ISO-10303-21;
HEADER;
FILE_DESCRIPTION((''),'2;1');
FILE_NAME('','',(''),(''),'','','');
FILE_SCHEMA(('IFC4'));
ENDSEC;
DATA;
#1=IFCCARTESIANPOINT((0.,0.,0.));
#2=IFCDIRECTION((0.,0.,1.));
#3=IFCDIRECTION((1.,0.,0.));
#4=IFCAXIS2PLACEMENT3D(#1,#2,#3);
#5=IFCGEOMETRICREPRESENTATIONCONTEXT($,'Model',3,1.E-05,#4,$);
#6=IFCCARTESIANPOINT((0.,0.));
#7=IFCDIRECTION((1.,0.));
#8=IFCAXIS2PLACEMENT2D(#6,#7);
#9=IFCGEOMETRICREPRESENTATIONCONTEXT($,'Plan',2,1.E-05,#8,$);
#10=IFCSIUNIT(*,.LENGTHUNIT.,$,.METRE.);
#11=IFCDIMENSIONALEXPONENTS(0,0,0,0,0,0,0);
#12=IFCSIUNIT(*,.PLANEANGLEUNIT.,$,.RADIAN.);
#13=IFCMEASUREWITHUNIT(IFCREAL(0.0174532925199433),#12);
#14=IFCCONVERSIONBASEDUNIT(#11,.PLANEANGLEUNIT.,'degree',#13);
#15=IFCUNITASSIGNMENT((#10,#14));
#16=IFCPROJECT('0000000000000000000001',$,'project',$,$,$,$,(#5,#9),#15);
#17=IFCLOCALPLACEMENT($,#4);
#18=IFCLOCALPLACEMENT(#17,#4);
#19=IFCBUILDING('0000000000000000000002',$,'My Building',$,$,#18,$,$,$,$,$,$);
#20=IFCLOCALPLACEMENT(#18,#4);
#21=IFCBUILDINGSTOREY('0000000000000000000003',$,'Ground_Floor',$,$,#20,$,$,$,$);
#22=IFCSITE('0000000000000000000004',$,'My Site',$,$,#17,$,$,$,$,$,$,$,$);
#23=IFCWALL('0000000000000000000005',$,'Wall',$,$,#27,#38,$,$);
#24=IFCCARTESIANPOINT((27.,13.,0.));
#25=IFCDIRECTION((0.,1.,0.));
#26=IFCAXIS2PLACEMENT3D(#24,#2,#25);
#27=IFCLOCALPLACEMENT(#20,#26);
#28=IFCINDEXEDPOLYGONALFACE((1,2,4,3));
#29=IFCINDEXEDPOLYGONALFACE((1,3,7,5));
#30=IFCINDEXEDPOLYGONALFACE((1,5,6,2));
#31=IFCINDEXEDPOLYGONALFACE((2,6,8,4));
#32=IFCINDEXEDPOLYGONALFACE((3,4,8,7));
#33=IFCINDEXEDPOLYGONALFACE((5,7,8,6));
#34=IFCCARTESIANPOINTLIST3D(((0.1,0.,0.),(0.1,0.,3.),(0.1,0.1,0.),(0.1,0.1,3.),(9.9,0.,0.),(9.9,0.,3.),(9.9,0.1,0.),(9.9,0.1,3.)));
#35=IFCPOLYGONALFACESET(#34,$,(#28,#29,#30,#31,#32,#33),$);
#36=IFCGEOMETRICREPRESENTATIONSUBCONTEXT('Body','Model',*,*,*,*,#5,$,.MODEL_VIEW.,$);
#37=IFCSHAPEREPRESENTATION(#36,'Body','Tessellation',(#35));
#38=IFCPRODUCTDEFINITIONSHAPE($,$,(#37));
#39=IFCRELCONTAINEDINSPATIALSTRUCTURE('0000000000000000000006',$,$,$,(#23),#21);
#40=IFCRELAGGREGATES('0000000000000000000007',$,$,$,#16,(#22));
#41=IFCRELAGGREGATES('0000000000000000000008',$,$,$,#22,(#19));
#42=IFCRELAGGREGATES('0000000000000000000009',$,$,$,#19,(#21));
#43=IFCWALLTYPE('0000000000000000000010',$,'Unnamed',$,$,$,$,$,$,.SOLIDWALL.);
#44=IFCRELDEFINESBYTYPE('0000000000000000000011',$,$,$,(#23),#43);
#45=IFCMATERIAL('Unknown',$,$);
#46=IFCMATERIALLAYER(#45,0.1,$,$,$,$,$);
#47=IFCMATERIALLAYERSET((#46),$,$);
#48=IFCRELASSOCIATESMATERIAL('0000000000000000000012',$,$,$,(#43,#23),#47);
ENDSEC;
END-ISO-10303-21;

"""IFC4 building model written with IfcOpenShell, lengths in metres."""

from ifc_helpers import new_model, entity, si_unit, converted_unit, frame, origin_with_axes, origin_2d_with_axis, place, context, subcontext, project, spatial, line, indexed_curve, outline, extrude, material, layer, layer_set, layer_usage, type_object, element, save


model = new_model("IFC4")

# Units and contexts
model_context = context("Model", 3, precision=1e-05, world=origin_with_axes())
plan_context = context("Plan", 2, precision=1e-05, world=origin_2d_with_axis())
body_context_1 = subcontext(model_context, "Body", "Model", "MODEL_VIEW")
ifc_project = project(units=[si_unit("LENGTHUNIT", "METRE"), converted_unit("PLANEANGLEUNIT", "degree", entity("IfcReal", 0.0174532925199433), si_unit("PLANEANGLEUNIT", "RADIAN"), dimensions=[0, 0, 0, 0, 0, 0, 0])], contexts=[model_context, plan_context])

# Site, building, storey
site_placement = place(None, origin_with_axes())
site = spatial("IfcSite", under=ifc_project, at=site_placement, Name="My Site")
building_placement = place(site_placement, origin_with_axes())
building = spatial("IfcBuilding", under=site, at=building_placement, Name="My Building")
storey_placement = place(building_placement, origin_with_axes())
storey = spatial("IfcBuildingStorey", under=building, at=storey_placement, Name="Ground_Floor")

# Shared definitions
ifc_material = material(Name="Unknown")
ifc_layer = layer(ifc_material, 0.1)
ifc_layer_set = layer_set([ifc_layer])
wall_type = type_object("IfcWallType", Name="Unnamed", PredefinedType="SOLIDWALL", material=ifc_layer_set)

# Wall
ifc_layer_usage_1 = layer_usage(ifc_layer_set, "AXIS2", "POSITIVE", 0.0)
wall_1_placement = place(storey_placement, frame((27.0, 13.0, 0.0), z_axis=(0.0, 0.0, 1.0), x_axis=(0.0, 1.0, 0.0)))
element("IfcWall", 1, at=wall_1_placement, inside=storey, type_object=wall_type, material=ifc_layer_usage_1, Name="Wall", context=body_context_1, shape_type="SweptSolid", body=[
    extrude(outline(indexed_curve([(0.1, 0.0), (0.1, 0.1), (9.9, 0.1), (9.9, 0.0)], segments=[line(1, 2, 3, 4, 1)])), origin_with_axes(), (0.0, 0.0, 1.0), 3.0),
])

save(model, "model.ifc")
